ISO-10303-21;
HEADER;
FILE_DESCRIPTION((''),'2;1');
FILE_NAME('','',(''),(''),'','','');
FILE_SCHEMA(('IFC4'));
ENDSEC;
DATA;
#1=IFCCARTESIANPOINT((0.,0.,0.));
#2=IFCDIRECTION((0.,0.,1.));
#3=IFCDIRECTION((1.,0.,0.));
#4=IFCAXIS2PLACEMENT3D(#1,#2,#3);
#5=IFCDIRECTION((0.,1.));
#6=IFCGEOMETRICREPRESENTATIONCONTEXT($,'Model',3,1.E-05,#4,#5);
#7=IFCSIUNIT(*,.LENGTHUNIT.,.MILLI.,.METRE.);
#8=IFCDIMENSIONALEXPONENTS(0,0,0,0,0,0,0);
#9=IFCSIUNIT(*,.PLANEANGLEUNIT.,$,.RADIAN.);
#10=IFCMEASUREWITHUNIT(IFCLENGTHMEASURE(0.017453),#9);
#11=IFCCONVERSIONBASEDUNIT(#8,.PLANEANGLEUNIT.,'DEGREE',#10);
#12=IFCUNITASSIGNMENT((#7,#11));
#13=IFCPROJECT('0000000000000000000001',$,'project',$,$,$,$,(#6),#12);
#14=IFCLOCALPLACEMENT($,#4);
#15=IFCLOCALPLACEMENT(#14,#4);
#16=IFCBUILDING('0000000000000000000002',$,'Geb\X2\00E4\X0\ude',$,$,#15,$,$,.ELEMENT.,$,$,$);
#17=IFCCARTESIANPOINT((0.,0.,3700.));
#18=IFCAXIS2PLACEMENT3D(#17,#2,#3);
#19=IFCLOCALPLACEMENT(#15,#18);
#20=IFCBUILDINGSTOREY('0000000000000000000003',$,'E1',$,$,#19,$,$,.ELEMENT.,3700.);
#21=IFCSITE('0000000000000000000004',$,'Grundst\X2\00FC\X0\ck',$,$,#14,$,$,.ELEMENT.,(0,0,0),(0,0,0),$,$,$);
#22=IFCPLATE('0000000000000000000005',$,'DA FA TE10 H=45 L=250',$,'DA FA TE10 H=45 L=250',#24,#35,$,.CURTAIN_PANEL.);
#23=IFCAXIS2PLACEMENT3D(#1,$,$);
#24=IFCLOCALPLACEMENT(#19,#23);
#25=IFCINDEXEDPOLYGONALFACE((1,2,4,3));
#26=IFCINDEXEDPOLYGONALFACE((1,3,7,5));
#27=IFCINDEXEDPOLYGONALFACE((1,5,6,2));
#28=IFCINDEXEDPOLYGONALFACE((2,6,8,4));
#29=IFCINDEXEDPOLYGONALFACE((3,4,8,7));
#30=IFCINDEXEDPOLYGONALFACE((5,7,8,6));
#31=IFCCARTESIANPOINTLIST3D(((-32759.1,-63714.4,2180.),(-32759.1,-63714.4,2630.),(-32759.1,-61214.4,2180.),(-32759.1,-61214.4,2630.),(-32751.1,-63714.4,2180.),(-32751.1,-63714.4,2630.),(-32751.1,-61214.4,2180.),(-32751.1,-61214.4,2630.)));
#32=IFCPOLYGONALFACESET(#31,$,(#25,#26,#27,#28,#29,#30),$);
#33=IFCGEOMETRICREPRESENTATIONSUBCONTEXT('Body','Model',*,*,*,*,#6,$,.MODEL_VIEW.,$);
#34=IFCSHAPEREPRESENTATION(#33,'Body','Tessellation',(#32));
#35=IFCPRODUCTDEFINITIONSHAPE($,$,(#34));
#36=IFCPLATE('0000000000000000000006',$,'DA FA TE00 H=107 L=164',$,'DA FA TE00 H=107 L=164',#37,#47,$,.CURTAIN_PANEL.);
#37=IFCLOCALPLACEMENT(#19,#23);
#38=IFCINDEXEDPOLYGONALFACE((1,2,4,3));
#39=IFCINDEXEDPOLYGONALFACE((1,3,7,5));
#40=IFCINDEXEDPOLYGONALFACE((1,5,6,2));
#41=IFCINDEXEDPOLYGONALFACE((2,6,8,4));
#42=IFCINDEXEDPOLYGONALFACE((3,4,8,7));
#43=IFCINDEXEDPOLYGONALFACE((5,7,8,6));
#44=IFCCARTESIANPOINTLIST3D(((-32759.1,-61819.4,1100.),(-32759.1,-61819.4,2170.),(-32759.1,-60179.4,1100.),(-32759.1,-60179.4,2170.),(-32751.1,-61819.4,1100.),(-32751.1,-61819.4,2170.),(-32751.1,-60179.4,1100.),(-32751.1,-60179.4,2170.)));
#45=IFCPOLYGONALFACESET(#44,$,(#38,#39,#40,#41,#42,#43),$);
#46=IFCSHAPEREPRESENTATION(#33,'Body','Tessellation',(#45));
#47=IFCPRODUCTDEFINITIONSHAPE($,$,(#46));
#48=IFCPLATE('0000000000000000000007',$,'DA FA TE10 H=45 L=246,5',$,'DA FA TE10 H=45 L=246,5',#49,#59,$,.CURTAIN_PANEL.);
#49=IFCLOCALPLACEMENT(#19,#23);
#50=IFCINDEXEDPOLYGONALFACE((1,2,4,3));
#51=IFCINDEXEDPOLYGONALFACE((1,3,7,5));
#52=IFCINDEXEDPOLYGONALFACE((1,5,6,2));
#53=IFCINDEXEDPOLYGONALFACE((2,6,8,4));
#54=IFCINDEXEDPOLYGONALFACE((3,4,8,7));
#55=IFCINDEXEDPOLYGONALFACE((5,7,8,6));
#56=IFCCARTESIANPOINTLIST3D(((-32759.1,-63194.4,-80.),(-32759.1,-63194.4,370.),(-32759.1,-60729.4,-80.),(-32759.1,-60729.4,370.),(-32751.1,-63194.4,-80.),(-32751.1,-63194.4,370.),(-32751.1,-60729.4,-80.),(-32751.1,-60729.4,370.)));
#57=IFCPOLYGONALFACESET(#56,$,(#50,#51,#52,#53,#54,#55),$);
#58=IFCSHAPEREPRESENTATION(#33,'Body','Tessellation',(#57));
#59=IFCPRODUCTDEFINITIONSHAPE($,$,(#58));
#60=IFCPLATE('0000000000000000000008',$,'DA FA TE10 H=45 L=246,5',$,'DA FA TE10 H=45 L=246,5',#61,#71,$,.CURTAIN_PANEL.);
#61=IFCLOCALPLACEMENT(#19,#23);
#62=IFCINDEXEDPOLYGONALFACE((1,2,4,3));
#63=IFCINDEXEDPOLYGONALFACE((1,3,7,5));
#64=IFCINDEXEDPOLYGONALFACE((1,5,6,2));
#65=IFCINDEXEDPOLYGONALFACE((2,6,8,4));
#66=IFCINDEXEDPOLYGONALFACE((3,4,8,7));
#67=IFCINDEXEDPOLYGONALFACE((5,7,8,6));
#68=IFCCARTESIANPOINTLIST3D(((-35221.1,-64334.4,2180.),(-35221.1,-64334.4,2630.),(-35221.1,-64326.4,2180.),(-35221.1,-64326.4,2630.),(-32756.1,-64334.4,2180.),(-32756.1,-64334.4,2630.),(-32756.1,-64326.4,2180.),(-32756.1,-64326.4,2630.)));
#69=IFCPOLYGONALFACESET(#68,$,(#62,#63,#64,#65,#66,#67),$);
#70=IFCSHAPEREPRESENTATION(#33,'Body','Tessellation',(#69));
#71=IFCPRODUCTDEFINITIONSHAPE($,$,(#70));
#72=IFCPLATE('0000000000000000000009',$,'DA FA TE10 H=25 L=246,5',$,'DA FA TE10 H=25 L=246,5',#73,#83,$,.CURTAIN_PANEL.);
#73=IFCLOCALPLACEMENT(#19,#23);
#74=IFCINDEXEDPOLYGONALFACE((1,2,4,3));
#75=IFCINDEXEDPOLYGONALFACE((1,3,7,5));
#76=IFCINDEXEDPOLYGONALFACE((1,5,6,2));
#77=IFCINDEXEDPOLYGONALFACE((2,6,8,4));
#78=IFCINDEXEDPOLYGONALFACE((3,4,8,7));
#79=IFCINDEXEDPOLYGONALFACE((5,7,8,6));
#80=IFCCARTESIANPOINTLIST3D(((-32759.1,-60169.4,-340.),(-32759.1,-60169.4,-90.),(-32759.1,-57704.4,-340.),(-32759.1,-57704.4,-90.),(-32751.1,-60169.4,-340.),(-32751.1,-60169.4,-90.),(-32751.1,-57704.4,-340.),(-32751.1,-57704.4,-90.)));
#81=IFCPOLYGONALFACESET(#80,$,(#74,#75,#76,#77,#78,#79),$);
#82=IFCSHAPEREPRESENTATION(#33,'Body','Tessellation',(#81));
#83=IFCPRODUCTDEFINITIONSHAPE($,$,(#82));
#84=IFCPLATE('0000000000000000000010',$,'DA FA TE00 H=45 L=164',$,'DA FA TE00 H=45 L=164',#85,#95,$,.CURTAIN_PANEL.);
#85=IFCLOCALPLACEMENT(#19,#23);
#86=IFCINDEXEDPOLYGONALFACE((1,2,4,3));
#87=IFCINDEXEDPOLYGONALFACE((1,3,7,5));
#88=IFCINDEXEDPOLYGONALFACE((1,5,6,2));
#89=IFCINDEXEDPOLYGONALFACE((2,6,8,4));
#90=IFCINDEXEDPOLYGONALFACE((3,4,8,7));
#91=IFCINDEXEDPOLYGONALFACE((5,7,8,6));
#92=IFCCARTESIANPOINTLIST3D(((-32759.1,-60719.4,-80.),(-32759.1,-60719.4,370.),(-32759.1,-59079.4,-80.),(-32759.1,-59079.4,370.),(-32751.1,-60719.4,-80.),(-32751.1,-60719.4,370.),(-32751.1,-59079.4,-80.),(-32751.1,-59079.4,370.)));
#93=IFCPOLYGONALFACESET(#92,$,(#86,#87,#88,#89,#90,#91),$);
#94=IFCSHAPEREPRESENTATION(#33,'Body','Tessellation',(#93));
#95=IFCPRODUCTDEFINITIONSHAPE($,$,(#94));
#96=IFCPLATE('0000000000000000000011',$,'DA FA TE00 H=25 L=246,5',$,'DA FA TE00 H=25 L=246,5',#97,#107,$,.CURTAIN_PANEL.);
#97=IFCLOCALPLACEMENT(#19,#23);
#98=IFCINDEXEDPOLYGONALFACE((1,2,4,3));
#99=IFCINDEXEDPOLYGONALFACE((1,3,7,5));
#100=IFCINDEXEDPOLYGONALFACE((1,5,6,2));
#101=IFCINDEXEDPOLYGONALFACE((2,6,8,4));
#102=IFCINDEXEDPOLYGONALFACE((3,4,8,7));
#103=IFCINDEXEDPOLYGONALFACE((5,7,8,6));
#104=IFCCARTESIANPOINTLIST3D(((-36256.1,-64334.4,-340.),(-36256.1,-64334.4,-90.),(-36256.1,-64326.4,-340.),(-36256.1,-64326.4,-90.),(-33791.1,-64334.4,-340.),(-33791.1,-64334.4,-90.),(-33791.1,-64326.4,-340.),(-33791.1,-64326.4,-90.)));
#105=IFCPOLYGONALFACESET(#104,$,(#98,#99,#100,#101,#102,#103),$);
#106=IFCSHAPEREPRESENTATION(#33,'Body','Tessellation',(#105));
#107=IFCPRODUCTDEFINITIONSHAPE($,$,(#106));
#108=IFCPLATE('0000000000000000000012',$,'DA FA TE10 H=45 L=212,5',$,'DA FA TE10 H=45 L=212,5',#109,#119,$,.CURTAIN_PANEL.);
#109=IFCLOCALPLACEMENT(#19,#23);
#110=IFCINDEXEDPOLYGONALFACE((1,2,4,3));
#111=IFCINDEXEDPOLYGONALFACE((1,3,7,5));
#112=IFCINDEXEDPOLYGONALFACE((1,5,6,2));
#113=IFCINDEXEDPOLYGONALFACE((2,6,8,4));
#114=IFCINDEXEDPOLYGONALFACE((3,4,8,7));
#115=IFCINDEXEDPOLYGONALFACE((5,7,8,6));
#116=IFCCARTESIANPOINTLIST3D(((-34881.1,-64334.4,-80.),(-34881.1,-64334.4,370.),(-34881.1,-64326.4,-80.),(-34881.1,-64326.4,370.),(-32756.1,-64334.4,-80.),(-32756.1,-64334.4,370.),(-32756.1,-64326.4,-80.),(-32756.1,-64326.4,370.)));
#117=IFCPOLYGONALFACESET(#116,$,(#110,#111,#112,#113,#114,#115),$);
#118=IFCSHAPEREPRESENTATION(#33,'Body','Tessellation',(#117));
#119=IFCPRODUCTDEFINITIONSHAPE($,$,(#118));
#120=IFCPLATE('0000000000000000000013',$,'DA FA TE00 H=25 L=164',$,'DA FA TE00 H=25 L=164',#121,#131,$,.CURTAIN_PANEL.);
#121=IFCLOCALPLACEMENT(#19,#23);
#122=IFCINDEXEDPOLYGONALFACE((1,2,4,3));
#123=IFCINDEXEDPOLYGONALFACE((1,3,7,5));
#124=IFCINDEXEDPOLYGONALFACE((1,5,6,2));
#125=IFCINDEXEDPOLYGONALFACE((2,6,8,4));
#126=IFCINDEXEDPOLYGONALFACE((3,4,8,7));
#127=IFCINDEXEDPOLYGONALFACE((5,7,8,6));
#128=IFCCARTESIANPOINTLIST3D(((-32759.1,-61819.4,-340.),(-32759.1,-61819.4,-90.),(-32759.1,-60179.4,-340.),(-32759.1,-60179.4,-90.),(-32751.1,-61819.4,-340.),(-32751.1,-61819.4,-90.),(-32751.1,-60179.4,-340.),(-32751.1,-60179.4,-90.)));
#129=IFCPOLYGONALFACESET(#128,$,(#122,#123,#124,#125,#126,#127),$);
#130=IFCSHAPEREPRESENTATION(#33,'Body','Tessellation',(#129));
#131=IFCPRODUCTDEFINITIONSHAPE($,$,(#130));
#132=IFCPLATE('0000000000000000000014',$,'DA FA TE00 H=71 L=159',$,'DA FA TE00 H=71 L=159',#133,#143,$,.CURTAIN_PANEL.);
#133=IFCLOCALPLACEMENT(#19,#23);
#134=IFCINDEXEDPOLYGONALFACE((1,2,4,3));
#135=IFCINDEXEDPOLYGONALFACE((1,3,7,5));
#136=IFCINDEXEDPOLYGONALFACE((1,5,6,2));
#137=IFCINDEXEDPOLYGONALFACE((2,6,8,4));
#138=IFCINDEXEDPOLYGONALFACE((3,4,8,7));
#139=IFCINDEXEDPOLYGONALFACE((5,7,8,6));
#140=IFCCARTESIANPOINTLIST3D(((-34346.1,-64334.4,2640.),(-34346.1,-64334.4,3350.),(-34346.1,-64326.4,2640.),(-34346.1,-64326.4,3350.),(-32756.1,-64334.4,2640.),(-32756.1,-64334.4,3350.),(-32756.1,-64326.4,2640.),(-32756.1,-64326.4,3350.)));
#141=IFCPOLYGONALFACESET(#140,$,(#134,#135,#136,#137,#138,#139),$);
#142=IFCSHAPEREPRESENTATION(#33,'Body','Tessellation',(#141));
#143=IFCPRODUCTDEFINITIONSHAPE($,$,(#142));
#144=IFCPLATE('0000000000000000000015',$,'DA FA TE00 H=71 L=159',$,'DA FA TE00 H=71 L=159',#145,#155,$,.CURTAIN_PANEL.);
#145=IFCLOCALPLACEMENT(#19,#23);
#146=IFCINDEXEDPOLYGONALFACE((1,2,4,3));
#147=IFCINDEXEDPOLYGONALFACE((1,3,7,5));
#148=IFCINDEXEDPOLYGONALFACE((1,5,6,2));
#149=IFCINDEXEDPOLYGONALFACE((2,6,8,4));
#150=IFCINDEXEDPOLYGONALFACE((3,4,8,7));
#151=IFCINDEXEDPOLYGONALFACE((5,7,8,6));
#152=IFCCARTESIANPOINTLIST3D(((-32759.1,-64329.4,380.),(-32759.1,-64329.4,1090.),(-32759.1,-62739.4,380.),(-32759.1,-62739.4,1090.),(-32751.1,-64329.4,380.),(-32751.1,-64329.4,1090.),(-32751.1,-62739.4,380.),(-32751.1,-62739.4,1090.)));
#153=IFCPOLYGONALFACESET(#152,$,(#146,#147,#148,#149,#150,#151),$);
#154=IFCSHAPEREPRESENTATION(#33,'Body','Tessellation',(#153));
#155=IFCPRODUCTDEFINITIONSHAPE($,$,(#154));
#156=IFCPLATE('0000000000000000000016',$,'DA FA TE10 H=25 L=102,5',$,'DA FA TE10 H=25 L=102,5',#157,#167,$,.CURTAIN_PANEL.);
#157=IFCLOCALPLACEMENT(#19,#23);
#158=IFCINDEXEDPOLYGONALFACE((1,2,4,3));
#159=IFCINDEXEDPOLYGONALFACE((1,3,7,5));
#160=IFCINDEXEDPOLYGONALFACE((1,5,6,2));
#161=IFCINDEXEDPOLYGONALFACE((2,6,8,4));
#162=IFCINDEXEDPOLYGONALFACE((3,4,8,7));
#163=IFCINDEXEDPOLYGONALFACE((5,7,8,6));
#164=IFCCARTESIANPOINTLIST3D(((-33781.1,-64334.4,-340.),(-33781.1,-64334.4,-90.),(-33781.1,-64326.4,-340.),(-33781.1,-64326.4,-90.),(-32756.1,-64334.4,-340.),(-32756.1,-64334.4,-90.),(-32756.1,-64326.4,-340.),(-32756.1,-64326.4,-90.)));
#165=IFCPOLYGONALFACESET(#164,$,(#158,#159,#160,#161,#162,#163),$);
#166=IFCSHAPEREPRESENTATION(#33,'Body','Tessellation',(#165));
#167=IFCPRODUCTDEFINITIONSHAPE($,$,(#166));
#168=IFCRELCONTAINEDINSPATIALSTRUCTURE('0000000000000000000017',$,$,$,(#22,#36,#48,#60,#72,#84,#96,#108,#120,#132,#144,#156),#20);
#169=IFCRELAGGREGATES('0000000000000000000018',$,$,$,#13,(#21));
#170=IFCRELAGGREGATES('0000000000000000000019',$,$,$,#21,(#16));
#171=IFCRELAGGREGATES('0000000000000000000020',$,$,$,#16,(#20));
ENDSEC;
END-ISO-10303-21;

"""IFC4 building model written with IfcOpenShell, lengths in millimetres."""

from ifc_helpers import new_model, entity, si_unit, converted_unit, direction, frame, origin_with_axes, place, context, subcontext, project, spatial, line, indexed_curve, outline, extrude, source, transform, mapped, element, save


model = new_model("IFC4")

# Units and contexts
model_context = context("Model", 3, precision=1e-05, world=origin_with_axes(), true_north=direction((0.0, 1.0)))
body_context = subcontext(model_context, "Body", "Model", "MODEL_VIEW")
ifc_project = project(units=[si_unit("LENGTHUNIT", "METRE", prefix="MILLI"), converted_unit("PLANEANGLEUNIT", "DEGREE", entity("IfcLengthMeasure", 0.017453), si_unit("PLANEANGLEUNIT", "RADIAN"), dimensions=[0, 0, 0, 0, 0, 0, 0])], contexts=[model_context])

# Site, building, storey
site_placement = place(None, origin_with_axes())
site = spatial("IfcSite", under=ifc_project, at=site_placement, Name="Grundstück", CompositionType="ELEMENT", RefLatitude=(0, 0, 0), RefLongitude=(0, 0, 0))
building_placement = place(site_placement, origin_with_axes())
building = spatial("IfcBuilding", under=site, at=building_placement, Name="Gebäude", CompositionType="ELEMENT")
storey_placement = place(building_placement, frame((0.0, 0.0, 3700.0), z_axis=(0.0, 0.0, 1.0), x_axis=(1.0, 0.0, 0.0)))
storey = spatial("IfcBuildingStorey", under=building, at=storey_placement, Name="E1", CompositionType="ELEMENT", Elevation=3700.0)

# Plates
shared_shape_1 = source(origin_with_axes(), body_context, "Body", "SweptSolid", [
    extrude(outline(indexed_curve([(-1250.0, 0.0), (1250.0, 0.0), (1250.0, 8.0), (-1250.0, 8.0)], segments=[line(1, 2), line(2, 3), line(3, 4), line(4, 1)])), frame((0.0, 0.0, 450.0), z_axis=(0.0, 0.0, 1.0), x_axis=(1.0, 0.0, 0.0)), (0.0, 0.0, -1.0), 450.0),
])
plate_1_placement = place(storey_placement, frame((-32751.1, -62464.4, 2180.0), z_axis=(0.0, 0.0, 1.0), x_axis=(0.0, 1.0, 0.0)))
element("IfcPlate", 1, at=plate_1_placement, inside=storey, Name="DA FA TE10 H=45 L=250", ObjectType="DA FA TE10 H=45 L=250", PredefinedType="CURTAIN_PANEL", context=body_context, shape_type="MappedRepresentation", body=[
    mapped(shared_shape_1, transform((0.0, 0.0, 0.0), x_axis=(1.0, 0.0, 0.0), y_axis=(0.0, 1.0, 0.0), z_axis=(0.0, 0.0, 1.0), scale=1.0)),
])
shared_shape_2 = source(origin_with_axes(), body_context, "Body", "SweptSolid", [
    extrude(outline(indexed_curve([(-820.0, 0.0), (820.0, 0.0), (820.0, 8.0), (-820.0, 8.0)], segments=[line(1, 2), line(2, 3), line(3, 4), line(4, 1)])), frame((0.0, 0.0, 1070.0), z_axis=(0.0, 0.0, 1.0), x_axis=(1.0, 0.0, 0.0)), (0.0, 0.0, -1.0), 1070.0),
])
plate_2_placement = place(storey_placement, frame((-32751.1, -60999.4, 1100.0), z_axis=(0.0, 0.0, 1.0), x_axis=(0.0, 1.0, 0.0)))
element("IfcPlate", 2, at=plate_2_placement, inside=storey, Name="DA FA TE00 H=107 L=164", ObjectType="DA FA TE00 H=107 L=164", PredefinedType="CURTAIN_PANEL", context=body_context, shape_type="MappedRepresentation", body=[
    mapped(shared_shape_2, transform((0.0, 0.0, 0.0), x_axis=(1.0, 0.0, 0.0), y_axis=(0.0, 1.0, 0.0), z_axis=(0.0, 0.0, 1.0), scale=1.0)),
])
shared_shape_3 = source(origin_with_axes(), body_context, "Body", "SweptSolid", [
    extrude(outline(indexed_curve([(-1232.5, 0.0), (1232.5, 0.0), (1232.5, 8.0), (-1232.5, 8.0)], segments=[line(1, 2), line(2, 3), line(3, 4), line(4, 1)])), frame((0.0, 0.0, 450.0), z_axis=(0.0, 0.0, 1.0), x_axis=(1.0, 0.0, 0.0)), (0.0, 0.0, -1.0), 450.0),
])
for number, where, z_axis, x_axis, name in (
    (3, (-32751.1, -61961.9, -80.0), (0.0, 0.0, 1.0), (0.0, 1.0, 0.0), "DA FA TE10 H=45 L=246,5"),
    (4, (-33988.6, -64334.4, 2180.0), (0.0, 0.0, 1.0), (1.0, 0.0, 0.0), "DA FA TE10 H=45 L=246,5"),
):
    element("IfcPlate", number, at=place(storey_placement, frame(where, z_axis=z_axis, x_axis=x_axis)), inside=storey, Name=name, ObjectType="DA FA TE10 H=45 L=246,5", PredefinedType="CURTAIN_PANEL", context=body_context, shape_type="MappedRepresentation", body=[
        mapped(shared_shape_3, transform((0.0, 0.0, 0.0), x_axis=(1.0, 0.0, 0.0), y_axis=(0.0, 1.0, 0.0), z_axis=(0.0, 0.0, 1.0), scale=1.0)),
    ])
shared_shape_4 = source(origin_with_axes(), body_context, "Body", "SweptSolid", [
    extrude(outline(indexed_curve([(-1232.5, 0.0), (1232.5, 0.0), (1232.5, 8.0), (-1232.5, 8.0)], segments=[line(1, 2), line(2, 3), line(3, 4), line(4, 1)])), frame((0.0, 0.0, 250.0), z_axis=(0.0, 0.0, 1.0), x_axis=(1.0, 0.0, 0.0)), (0.0, 0.0, -1.0), 250.0),
])
plate_3_placement = place(storey_placement, frame((-32751.1, -58936.9, -340.0), z_axis=(0.0, 0.0, 1.0), x_axis=(0.0, 1.0, 0.0)))
element("IfcPlate", 5, at=plate_3_placement, inside=storey, Name="DA FA TE10 H=25 L=246,5", ObjectType="DA FA TE10 H=25 L=246,5", PredefinedType="CURTAIN_PANEL", context=body_context, shape_type="MappedRepresentation", body=[
    mapped(shared_shape_4, transform((0.0, 0.0, 0.0), x_axis=(1.0, 0.0, 0.0), y_axis=(0.0, 1.0, 0.0), z_axis=(0.0, 0.0, 1.0), scale=1.0)),
])
shared_shape_5 = source(origin_with_axes(), body_context, "Body", "SweptSolid", [
    extrude(outline(indexed_curve([(-820.0, 0.0), (820.0, 0.0), (820.0, 8.0), (-820.0, 8.0)], segments=[line(1, 2), line(2, 3), line(3, 4), line(4, 1)])), frame((0.0, 0.0, 450.0), z_axis=(0.0, 0.0, 1.0), x_axis=(1.0, 0.0, 0.0)), (0.0, 0.0, -1.0), 450.0),
])
plate_4_placement = place(storey_placement, frame((-32751.1, -59899.4, -80.0), z_axis=(0.0, 0.0, 1.0), x_axis=(0.0, 1.0, 0.0)))
element("IfcPlate", 6, at=plate_4_placement, inside=storey, Name="DA FA TE00 H=45 L=164", ObjectType="DA FA TE00 H=45 L=164", PredefinedType="CURTAIN_PANEL", context=body_context, shape_type="MappedRepresentation", body=[
    mapped(shared_shape_5, transform((0.0, 0.0, 0.0), x_axis=(1.0, 0.0, 0.0), y_axis=(0.0, 1.0, 0.0), z_axis=(0.0, 0.0, 1.0), scale=1.0)),
])
shared_shape_6 = source(origin_with_axes(), body_context, "Body", "SweptSolid", [
    extrude(outline(indexed_curve([(-1232.5, 0.0), (1232.5, 0.0), (1232.5, 8.0), (-1232.5, 8.0)], segments=[line(1, 2), line(2, 3), line(3, 4), line(4, 1)])), frame((0.0, 0.0, 250.0), z_axis=(0.0, 0.0, 1.0), x_axis=(1.0, 0.0, 0.0)), (0.0, 0.0, -1.0), 250.0),
])
plate_5_placement = place(storey_placement, frame((-35023.6, -64334.4, -340.0), z_axis=(0.0, 0.0, 1.0), x_axis=(1.0, 0.0, 0.0)))
element("IfcPlate", 7, at=plate_5_placement, inside=storey, Name="DA FA TE00 H=25 L=246,5", ObjectType="DA FA TE00 H=25 L=246,5", PredefinedType="CURTAIN_PANEL", context=body_context, shape_type="MappedRepresentation", body=[
    mapped(shared_shape_6, transform((0.0, 0.0, 0.0), x_axis=(1.0, 0.0, 0.0), y_axis=(0.0, 1.0, 0.0), z_axis=(0.0, 0.0, 1.0), scale=1.0)),
])
shared_shape_7 = source(origin_with_axes(), body_context, "Body", "SweptSolid", [
    extrude(outline(indexed_curve([(-1062.5, 0.0), (1062.5, 0.0), (1062.5, 8.0), (-1062.5, 8.0)], segments=[line(1, 2), line(2, 3), line(3, 4), line(4, 1)])), frame((0.0, 0.0, 450.0), z_axis=(0.0, 0.0, 1.0), x_axis=(1.0, 0.0, 0.0)), (0.0, 0.0, -1.0), 450.0),
])
plate_6_placement = place(storey_placement, frame((-33818.6, -64334.4, -80.0), z_axis=(0.0, 0.0, 1.0), x_axis=(1.0, 0.0, 0.0)))
element("IfcPlate", 8, at=plate_6_placement, inside=storey, Name="DA FA TE10 H=45 L=212,5", ObjectType="DA FA TE10 H=45 L=212,5", PredefinedType="CURTAIN_PANEL", context=body_context, shape_type="MappedRepresentation", body=[
    mapped(shared_shape_7, transform((0.0, 0.0, 0.0), x_axis=(1.0, 0.0, 0.0), y_axis=(0.0, 1.0, 0.0), z_axis=(0.0, 0.0, 1.0), scale=1.0)),
])
shared_shape_8 = source(origin_with_axes(), body_context, "Body", "SweptSolid", [
    extrude(outline(indexed_curve([(-820.0, 0.0), (820.0, 0.0), (820.0, 8.0), (-820.0, 8.0)], segments=[line(1, 2), line(2, 3), line(3, 4), line(4, 1)])), frame((0.0, 0.0, 250.0), z_axis=(0.0, 0.0, 1.0), x_axis=(1.0, 0.0, 0.0)), (0.0, 0.0, -1.0), 250.0),
])
plate_7_placement = place(storey_placement, frame((-32751.1, -60999.4, -340.0), z_axis=(0.0, 0.0, 1.0), x_axis=(0.0, 1.0, 0.0)))
element("IfcPlate", 9, at=plate_7_placement, inside=storey, Name="DA FA TE00 H=25 L=164", ObjectType="DA FA TE00 H=25 L=164", PredefinedType="CURTAIN_PANEL", context=body_context, shape_type="MappedRepresentation", body=[
    mapped(shared_shape_8, transform((0.0, 0.0, 0.0), x_axis=(1.0, 0.0, 0.0), y_axis=(0.0, 1.0, 0.0), z_axis=(0.0, 0.0, 1.0), scale=1.0)),
])
shared_shape_9 = source(origin_with_axes(), body_context, "Body", "SweptSolid", [
    extrude(outline(indexed_curve([(-795.0, 0.0), (795.0, 0.0), (795.0, 8.0), (-795.0, 8.0)], segments=[line(1, 2), line(2, 3), line(3, 4), line(4, 1)])), frame((0.0, 0.0, 710.0), z_axis=(0.0, 0.0, 1.0), x_axis=(1.0, 0.0, 0.0)), (0.0, 0.0, -1.0), 710.0),
])
for number, where, z_axis, x_axis, name in (
    (10, (-33551.1, -64334.4, 2640.0), (0.0, 0.0, 1.0), (1.0, 0.0, 0.0), "DA FA TE00 H=71 L=159"),
    (11, (-32751.1, -63534.4, 380.0), (0.0, 0.0, 1.0), (0.0, 1.0, 0.0), "DA FA TE00 H=71 L=159"),
):
    element("IfcPlate", number, at=place(storey_placement, frame(where, z_axis=z_axis, x_axis=x_axis)), inside=storey, Name=name, ObjectType="DA FA TE00 H=71 L=159", PredefinedType="CURTAIN_PANEL", context=body_context, shape_type="MappedRepresentation", body=[
        mapped(shared_shape_9, transform((0.0, 0.0, 0.0), x_axis=(1.0, 0.0, 0.0), y_axis=(0.0, 1.0, 0.0), z_axis=(0.0, 0.0, 1.0), scale=1.0)),
    ])
shared_shape_10 = source(origin_with_axes(), body_context, "Body", "SweptSolid", [
    extrude(outline(indexed_curve([(-512.5, 0.0), (512.5, 0.0), (512.5, 8.0), (-512.5, 8.0)], segments=[line(1, 2), line(2, 3), line(3, 4), line(4, 1)])), frame((0.0, 0.0, 250.0), z_axis=(0.0, 0.0, 1.0), x_axis=(1.0, 0.0, 0.0)), (0.0, 0.0, -1.0), 250.0),
])
plate_8_placement = place(storey_placement, frame((-33268.6, -64334.4, -340.0), z_axis=(0.0, 0.0, 1.0), x_axis=(1.0, 0.0, 0.0)))
element("IfcPlate", 12, at=plate_8_placement, inside=storey, Name="DA FA TE10 H=25 L=102,5", ObjectType="DA FA TE10 H=25 L=102,5", PredefinedType="CURTAIN_PANEL", context=body_context, shape_type="MappedRepresentation", body=[
    mapped(shared_shape_10, transform((0.0, 0.0, 0.0), x_axis=(1.0, 0.0, 0.0), y_axis=(0.0, 1.0, 0.0), z_axis=(0.0, 0.0, 1.0), scale=1.0)),
])

save(model, "model.ifc")
